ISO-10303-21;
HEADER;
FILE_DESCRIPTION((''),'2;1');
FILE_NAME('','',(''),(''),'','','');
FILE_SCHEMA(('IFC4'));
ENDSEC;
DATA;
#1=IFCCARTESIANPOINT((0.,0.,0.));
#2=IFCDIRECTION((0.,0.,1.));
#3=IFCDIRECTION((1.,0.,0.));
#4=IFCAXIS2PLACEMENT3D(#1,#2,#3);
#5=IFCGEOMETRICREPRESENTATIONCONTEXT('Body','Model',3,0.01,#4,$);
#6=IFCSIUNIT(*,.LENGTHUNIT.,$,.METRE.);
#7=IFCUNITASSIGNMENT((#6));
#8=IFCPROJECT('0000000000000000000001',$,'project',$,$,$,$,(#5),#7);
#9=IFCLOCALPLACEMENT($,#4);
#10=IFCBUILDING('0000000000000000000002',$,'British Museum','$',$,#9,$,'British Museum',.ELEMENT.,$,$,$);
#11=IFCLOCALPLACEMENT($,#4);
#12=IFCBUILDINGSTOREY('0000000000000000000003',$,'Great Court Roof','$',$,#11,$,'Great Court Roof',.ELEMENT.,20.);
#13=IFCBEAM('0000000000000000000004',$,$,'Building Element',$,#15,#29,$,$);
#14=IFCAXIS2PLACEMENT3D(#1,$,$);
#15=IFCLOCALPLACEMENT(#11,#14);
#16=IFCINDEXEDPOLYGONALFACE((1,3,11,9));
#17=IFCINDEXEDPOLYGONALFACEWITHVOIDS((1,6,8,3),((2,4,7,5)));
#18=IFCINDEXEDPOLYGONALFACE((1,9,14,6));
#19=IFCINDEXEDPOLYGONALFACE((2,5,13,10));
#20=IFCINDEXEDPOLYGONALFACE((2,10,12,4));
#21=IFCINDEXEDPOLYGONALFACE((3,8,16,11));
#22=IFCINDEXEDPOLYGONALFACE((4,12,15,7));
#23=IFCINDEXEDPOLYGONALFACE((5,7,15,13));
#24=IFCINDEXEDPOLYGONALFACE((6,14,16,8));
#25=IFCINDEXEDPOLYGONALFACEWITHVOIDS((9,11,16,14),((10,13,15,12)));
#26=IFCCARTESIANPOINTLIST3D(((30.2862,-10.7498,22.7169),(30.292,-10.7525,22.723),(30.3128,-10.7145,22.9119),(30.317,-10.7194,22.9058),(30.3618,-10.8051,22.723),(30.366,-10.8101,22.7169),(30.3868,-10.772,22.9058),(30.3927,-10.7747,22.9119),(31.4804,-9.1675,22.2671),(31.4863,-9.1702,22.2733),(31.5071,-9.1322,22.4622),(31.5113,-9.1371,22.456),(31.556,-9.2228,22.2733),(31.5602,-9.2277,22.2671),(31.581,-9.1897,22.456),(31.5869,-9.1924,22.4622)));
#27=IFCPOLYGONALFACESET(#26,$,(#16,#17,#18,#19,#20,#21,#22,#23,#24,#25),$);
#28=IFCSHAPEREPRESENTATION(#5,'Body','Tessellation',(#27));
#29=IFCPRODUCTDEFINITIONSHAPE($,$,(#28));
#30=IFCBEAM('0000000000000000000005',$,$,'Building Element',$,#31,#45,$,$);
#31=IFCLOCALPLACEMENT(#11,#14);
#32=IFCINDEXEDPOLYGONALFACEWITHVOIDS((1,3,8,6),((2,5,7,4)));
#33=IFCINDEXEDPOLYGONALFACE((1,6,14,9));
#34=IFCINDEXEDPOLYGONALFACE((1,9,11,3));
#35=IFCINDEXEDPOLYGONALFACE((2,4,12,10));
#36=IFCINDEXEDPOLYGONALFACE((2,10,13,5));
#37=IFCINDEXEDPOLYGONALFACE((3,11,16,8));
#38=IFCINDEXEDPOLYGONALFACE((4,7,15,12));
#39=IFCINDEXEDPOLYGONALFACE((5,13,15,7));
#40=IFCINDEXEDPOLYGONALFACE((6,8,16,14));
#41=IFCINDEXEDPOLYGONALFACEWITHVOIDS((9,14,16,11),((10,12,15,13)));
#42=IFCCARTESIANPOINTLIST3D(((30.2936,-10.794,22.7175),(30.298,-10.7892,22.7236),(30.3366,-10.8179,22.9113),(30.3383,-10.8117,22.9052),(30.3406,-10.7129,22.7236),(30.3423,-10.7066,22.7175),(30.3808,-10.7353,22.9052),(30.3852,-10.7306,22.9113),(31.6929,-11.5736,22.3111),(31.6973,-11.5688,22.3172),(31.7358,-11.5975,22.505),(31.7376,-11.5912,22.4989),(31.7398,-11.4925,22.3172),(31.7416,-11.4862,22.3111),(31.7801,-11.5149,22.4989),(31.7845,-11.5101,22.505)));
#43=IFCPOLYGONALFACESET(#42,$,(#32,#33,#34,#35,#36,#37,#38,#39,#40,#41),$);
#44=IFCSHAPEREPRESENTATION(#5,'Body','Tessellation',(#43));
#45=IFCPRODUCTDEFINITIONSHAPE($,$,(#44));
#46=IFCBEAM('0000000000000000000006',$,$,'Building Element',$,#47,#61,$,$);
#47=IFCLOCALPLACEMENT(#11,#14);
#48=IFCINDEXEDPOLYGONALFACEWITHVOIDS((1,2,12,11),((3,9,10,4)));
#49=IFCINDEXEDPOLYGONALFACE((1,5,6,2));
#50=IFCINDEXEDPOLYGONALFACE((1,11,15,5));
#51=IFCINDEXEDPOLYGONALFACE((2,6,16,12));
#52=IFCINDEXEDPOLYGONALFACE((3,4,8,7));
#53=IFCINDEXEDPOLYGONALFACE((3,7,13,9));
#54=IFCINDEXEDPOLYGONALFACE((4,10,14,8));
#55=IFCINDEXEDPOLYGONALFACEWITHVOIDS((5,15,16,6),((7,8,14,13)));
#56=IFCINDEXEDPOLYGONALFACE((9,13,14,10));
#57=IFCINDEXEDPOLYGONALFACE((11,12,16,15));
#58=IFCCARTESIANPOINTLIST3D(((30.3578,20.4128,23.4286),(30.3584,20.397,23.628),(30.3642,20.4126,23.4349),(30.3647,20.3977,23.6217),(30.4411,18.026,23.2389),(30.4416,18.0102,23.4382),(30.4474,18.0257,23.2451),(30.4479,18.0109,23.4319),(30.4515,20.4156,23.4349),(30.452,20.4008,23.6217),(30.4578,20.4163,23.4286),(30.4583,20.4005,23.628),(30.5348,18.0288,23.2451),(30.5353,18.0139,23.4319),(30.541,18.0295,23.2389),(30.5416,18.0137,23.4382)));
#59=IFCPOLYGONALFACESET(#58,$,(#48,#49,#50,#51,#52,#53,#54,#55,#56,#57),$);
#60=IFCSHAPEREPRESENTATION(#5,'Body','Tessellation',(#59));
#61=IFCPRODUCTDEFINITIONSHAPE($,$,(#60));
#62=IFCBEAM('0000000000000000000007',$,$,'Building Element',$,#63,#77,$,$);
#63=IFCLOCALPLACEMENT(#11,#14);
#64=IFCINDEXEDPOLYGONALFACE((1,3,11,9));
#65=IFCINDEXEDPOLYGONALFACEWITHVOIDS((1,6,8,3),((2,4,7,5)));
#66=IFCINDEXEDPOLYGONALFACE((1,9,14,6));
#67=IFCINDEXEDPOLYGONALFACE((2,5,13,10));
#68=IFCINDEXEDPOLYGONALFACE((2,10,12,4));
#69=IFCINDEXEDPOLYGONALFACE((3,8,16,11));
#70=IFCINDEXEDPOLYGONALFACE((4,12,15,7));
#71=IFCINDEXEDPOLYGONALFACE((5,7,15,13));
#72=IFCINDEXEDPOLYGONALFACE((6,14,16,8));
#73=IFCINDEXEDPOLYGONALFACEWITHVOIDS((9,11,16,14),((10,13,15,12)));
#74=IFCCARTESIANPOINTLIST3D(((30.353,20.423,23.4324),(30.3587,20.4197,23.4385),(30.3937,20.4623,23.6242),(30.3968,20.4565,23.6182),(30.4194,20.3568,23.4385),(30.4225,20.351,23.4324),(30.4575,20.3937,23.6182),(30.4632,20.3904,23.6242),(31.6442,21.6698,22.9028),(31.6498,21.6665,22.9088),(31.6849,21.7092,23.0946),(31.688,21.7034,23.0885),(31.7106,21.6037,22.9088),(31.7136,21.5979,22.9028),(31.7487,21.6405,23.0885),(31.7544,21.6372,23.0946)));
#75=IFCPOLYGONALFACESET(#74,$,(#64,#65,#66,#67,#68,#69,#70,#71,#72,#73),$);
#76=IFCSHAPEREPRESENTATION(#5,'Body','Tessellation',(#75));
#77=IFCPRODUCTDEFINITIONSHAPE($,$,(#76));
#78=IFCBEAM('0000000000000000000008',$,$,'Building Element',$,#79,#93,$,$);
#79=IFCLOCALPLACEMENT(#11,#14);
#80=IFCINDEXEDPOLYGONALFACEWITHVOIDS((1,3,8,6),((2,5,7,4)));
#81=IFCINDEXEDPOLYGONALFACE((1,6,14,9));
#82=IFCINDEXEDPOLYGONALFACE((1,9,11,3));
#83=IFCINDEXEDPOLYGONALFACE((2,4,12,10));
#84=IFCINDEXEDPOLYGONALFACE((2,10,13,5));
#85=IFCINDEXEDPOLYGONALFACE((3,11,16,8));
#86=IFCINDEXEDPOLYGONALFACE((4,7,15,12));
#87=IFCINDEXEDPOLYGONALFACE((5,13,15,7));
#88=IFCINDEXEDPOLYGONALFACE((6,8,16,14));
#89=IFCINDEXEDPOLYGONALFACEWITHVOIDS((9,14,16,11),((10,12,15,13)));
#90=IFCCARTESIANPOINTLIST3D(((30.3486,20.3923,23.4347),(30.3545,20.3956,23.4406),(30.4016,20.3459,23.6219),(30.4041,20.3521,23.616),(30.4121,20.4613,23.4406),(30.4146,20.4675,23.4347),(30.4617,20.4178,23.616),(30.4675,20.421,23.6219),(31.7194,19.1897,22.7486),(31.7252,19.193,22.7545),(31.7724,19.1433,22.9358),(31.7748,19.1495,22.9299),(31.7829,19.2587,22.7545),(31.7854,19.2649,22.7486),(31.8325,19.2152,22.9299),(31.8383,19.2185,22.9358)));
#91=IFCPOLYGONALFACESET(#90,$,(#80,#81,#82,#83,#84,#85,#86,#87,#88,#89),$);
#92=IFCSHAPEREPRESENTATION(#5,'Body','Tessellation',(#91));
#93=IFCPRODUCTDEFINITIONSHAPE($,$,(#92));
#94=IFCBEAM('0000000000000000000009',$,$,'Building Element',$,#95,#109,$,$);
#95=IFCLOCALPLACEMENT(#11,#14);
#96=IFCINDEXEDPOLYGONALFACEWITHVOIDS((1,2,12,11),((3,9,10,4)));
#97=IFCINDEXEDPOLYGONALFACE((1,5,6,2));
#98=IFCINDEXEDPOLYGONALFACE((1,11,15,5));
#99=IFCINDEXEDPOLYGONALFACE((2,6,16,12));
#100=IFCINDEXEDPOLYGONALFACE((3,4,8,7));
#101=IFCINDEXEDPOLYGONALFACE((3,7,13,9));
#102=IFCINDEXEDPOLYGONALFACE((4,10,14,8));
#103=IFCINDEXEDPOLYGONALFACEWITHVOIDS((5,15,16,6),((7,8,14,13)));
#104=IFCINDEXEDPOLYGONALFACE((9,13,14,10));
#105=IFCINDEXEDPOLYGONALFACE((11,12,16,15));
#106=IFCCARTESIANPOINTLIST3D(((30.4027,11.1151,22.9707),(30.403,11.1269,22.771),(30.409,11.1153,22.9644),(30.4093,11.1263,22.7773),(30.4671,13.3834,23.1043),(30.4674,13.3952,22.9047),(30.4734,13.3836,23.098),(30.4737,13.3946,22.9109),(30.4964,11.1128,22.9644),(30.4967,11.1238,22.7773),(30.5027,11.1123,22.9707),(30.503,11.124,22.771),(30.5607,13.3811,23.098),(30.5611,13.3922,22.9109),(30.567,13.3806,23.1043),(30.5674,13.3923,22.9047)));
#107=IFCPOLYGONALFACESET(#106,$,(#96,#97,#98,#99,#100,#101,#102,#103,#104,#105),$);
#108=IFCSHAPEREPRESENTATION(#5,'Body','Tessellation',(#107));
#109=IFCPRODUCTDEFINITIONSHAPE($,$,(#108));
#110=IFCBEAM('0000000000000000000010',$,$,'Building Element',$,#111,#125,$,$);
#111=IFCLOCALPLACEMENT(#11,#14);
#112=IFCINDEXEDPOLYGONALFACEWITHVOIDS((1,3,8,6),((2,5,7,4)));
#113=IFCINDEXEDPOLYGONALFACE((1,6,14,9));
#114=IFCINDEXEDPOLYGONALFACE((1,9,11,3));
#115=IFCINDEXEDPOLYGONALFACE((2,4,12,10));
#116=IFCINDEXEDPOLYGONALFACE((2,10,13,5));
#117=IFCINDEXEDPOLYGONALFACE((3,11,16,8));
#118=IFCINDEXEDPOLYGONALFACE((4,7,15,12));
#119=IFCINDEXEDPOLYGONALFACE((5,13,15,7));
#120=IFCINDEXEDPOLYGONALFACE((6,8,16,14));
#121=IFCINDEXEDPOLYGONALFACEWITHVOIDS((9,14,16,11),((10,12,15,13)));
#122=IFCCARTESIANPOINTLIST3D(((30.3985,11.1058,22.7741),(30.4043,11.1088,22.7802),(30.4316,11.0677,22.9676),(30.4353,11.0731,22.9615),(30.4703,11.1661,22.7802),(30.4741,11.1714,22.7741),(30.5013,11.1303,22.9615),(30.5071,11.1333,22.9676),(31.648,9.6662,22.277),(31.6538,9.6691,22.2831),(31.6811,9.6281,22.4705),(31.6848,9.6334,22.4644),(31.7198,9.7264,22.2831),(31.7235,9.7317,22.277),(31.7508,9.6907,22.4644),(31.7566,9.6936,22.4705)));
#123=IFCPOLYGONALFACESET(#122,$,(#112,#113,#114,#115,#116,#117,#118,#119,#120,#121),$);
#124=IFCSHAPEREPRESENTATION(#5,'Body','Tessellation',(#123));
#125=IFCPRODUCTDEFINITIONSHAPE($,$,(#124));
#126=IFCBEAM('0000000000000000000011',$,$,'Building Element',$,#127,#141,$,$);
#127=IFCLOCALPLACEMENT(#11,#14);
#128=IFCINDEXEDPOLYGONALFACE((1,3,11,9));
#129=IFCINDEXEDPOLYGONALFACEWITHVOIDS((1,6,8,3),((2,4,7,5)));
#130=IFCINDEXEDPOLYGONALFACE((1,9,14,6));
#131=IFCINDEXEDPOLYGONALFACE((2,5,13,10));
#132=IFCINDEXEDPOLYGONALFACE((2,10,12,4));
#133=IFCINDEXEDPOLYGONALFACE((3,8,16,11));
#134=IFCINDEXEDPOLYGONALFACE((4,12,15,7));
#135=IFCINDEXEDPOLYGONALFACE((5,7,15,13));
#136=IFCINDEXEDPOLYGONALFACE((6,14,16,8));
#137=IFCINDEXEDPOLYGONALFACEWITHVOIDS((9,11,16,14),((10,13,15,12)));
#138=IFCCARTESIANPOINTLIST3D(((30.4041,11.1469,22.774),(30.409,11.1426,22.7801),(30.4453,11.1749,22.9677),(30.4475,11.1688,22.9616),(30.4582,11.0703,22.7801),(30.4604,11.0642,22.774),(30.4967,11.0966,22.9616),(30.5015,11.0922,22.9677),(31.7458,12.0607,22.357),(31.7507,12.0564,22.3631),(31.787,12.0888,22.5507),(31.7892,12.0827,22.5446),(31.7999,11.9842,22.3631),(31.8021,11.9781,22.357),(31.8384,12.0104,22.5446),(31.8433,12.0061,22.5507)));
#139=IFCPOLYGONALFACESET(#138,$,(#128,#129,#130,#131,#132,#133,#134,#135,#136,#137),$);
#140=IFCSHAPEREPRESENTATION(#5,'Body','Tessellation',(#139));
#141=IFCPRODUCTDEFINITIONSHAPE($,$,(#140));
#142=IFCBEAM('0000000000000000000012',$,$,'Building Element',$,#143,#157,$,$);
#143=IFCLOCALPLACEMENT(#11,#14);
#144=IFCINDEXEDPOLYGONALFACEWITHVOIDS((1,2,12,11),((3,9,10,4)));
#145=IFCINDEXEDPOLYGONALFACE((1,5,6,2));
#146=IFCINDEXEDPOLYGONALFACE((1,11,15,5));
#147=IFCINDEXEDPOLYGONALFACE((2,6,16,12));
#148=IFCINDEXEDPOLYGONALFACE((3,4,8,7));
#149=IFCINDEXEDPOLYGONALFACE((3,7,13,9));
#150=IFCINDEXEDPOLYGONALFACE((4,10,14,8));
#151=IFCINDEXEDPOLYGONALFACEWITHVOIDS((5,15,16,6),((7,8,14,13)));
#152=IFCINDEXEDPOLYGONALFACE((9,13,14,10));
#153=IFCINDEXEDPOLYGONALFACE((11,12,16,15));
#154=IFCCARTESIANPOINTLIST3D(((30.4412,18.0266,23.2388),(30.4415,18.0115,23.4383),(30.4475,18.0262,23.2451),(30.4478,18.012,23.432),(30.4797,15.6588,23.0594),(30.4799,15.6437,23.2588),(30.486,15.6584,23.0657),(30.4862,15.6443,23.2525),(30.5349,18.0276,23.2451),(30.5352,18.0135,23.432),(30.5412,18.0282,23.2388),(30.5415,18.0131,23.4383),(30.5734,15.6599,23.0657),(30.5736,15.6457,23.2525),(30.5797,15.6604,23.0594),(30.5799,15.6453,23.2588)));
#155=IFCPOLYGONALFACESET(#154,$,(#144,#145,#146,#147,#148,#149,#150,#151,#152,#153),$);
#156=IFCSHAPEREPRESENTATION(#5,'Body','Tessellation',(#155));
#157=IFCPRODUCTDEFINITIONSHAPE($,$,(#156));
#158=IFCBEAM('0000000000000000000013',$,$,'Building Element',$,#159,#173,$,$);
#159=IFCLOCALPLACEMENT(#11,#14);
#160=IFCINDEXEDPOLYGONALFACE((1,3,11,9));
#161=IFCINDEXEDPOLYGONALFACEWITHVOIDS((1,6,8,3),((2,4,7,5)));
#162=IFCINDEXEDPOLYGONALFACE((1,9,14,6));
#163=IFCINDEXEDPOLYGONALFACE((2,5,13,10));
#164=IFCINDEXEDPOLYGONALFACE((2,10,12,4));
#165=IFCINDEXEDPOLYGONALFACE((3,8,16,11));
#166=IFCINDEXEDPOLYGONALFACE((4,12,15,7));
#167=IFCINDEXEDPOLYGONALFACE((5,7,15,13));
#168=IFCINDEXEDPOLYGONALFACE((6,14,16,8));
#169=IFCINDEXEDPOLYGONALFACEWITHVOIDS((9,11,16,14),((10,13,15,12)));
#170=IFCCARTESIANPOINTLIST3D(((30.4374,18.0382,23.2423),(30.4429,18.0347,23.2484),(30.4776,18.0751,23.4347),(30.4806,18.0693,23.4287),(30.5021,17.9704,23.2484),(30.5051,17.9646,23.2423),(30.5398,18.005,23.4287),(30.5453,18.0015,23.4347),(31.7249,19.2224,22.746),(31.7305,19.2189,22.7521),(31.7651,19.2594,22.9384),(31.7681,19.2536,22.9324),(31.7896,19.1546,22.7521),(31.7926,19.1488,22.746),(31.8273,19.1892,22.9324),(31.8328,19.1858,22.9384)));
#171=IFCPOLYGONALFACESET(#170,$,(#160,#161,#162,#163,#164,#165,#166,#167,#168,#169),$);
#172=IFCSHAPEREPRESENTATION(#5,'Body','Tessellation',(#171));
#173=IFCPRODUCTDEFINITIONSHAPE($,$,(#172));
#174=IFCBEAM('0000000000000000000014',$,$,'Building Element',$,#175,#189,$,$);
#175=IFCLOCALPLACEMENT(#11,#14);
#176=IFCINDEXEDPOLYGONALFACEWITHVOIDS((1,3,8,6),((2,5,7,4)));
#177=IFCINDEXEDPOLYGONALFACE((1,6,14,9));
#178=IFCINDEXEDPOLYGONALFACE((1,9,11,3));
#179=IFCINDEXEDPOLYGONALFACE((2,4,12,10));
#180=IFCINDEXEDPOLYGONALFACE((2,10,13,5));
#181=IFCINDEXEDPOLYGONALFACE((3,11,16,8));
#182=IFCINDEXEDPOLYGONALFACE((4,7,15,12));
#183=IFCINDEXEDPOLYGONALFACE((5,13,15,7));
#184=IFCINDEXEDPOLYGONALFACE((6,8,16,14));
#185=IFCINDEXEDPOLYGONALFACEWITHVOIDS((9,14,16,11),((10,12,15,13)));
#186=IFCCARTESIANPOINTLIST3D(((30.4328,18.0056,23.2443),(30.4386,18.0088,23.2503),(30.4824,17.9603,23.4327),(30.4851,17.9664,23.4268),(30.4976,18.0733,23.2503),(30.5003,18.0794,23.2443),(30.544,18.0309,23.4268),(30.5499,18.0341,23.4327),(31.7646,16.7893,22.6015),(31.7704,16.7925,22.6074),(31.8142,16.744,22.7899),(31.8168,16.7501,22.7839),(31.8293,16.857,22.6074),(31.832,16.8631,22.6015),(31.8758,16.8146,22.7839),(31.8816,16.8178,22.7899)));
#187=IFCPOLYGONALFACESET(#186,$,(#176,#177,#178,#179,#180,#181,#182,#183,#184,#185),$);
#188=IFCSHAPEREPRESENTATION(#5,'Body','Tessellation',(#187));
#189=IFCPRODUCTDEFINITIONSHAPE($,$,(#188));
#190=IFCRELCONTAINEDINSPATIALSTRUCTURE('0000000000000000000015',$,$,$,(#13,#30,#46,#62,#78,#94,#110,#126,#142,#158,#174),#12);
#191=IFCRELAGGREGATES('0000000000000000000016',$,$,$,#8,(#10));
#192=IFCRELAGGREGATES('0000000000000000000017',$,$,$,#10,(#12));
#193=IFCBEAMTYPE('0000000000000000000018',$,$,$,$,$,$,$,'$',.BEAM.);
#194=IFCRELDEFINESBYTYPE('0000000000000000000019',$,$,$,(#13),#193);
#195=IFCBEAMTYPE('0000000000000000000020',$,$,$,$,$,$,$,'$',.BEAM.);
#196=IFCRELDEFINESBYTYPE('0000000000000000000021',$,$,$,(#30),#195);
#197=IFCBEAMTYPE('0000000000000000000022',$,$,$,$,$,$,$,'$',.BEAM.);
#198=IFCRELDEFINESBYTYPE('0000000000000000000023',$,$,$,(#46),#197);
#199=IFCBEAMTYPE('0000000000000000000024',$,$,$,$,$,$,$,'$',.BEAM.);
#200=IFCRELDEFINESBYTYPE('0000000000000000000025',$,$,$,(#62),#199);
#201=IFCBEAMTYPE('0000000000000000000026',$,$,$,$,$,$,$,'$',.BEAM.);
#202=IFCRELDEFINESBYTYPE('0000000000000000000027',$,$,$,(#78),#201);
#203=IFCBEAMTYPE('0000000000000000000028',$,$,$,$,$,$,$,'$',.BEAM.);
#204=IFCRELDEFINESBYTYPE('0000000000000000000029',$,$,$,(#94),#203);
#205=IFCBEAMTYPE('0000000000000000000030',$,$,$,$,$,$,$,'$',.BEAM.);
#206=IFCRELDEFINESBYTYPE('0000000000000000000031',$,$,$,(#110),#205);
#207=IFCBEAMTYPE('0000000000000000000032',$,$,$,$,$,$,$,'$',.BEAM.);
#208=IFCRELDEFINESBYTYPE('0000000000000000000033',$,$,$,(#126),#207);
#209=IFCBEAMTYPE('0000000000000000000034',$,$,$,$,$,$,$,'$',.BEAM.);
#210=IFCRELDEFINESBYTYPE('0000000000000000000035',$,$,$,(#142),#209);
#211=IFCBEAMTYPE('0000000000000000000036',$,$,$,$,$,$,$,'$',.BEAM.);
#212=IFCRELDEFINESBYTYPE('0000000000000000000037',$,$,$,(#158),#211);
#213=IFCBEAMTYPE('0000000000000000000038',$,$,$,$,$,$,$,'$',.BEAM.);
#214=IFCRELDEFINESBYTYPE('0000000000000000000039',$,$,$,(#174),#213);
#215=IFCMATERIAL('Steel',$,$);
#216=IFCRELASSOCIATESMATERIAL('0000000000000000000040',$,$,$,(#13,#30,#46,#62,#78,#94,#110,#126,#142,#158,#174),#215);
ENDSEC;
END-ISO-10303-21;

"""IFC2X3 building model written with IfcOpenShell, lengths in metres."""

from ifc_helpers import new_model, si_unit, frame, origin_with_axes, origin_2d, place, context, project, spatial, hollow_rectangle, extrude, material, type_object, element, save


model = new_model("IFC2X3")

# Units and contexts
model_context = context("Model", 3, precision=0.01, world=origin_with_axes(), identifier="Body")
ifc_project = project(units=[si_unit("LENGTHUNIT", "METRE")], contexts=[model_context])

# Building, storey
building_placement = place(None, origin_with_axes())
building = spatial("IfcBuilding", under=ifc_project, at=building_placement, Name="British Museum", Description="$", LongName="British Museum", CompositionType="ELEMENT")
storey_placement = place(None, origin_with_axes())
storey = spatial("IfcBuildingStorey", under=building, at=storey_placement, Name="Great Court Roof", Description="$", LongName="Great Court Roof", CompositionType="ELEMENT", Elevation=20.0)

# Beams
ifc_material = material(Name="Steel")
beam_type_1 = type_object("IfcBeamType", ElementType="$", PredefinedType="BEAM")
beam_1_placement = place(None, origin_with_axes())
element("IfcBeam", 1, at=beam_1_placement, inside=storey, type_object=beam_type_1, material=ifc_material, Description="Building Element", context=model_context, shape_type="SweptSolid", body=[
    extrude(hollow_rectangle(XDim=0.1, YDim=0.2, WallThickness=0.0063, InnerFilletRadius=-0.0063, OuterFilletRadius=0.0, at=origin_2d()), frame((30.3394, -10.7623, 22.8144), z_axis=(0.58749, 0.778397, -0.221254), x_axis=(-0.798179, 0.602421, 0.0)), (0.0, 0.0, 1.0), 2.0328),
])
beam_type_2 = type_object("IfcBeamType", ElementType="$", PredefinedType="BEAM")
beam_2_placement = place(None, origin_with_axes())
element("IfcBeam", 2, at=beam_2_placement, inside=storey, type_object=beam_type_2, material=ifc_material, Description="Building Element", context=model_context, shape_type="SweptSolid", body=[
    extrude(hollow_rectangle(XDim=0.1, YDim=0.2, WallThickness=0.0063, InnerFilletRadius=-0.0063, OuterFilletRadius=0.0, at=origin_2d()), frame((30.3394, -10.7623, 22.8144), z_axis=(0.846754, -0.471749, -0.245886), x_axis=(0.486691, 0.873574, 0.0)), (0.0, 0.0, 1.0), 1.6525),
])
beam_type_3 = type_object("IfcBeamType", ElementType="$", PredefinedType="BEAM")
beam_3_placement = place(None, origin_with_axes())
element("IfcBeam", 3, at=beam_3_placement, inside=storey, type_object=beam_type_3, material=ifc_material, Description="Building Element", context=model_context, shape_type="SweptSolid", body=[
    extrude(hollow_rectangle(XDim=0.1, YDim=0.2, WallThickness=0.0063, InnerFilletRadius=-0.0063, OuterFilletRadius=0.0, at=origin_2d()), frame((30.4081, 20.4067, 23.5283), z_axis=(0.03475, -0.996252, -0.079214), x_axis=(0.999392, 0.034859, 0.0)), (0.0, 0.0, 1.0), 2.3958),
])
beam_type_4 = type_object("IfcBeamType", ElementType="$", PredefinedType="BEAM")
beam_4_placement = place(None, origin_with_axes())
element("IfcBeam", 4, at=beam_4_placement, inside=storey, type_object=beam_type_4, material=ifc_material, Description="Building Element", context=model_context, shape_type="SweptSolid", body=[
    extrude(hollow_rectangle(XDim=0.1, YDim=0.2, WallThickness=0.0063, InnerFilletRadius=-0.0063, OuterFilletRadius=0.0, at=origin_2d()), frame((30.4081, 20.4067, 23.5283), z_axis=(0.689934, 0.666252, -0.28302), x_axis=(-0.694653, 0.719345, 0.0)), (0.0, 0.0, 1.0), 1.8715),
])
beam_type_5 = type_object("IfcBeamType", ElementType="$", PredefinedType="BEAM")
beam_5_placement = place(None, origin_with_axes())
element("IfcBeam", 5, at=beam_5_placement, inside=storey, type_object=beam_type_5, material=ifc_material, Description="Building Element", context=model_context, shape_type="SweptSolid", body=[
    extrude(hollow_rectangle(XDim=0.1, YDim=0.2, WallThickness=0.0063, InnerFilletRadius=-0.0063, OuterFilletRadius=0.0, at=origin_2d()), frame((30.4081, 20.4067, 23.5283), z_axis=(0.703565, -0.61724, -0.352153), x_axis=(0.659485, 0.751718, 0.0)), (0.0, 0.0, 1.0), 1.9483),
])
beam_type_6 = type_object("IfcBeamType", ElementType="$", PredefinedType="BEAM")
beam_6_placement = place(None, origin_with_axes())
element("IfcBeam", 6, at=beam_6_placement, inside=storey, type_object=beam_type_6, material=ifc_material, Description="Building Element", context=model_context, shape_type="SweptSolid", body=[
    extrude(hollow_rectangle(XDim=0.1, YDim=0.2, WallThickness=0.0063, InnerFilletRadius=-0.0063, OuterFilletRadius=0.0, at=origin_2d()), frame((30.4528, 11.1196, 22.8708), z_axis=(0.028319, 0.997869, 0.058792), x_axis=(-0.999598, 0.028368, 0.0)), (0.0, 0.0, 1.0), 2.2732),
])
beam_type_7 = type_object("IfcBeamType", ElementType="$", PredefinedType="BEAM")
beam_7_placement = place(None, origin_with_axes())
element("IfcBeam", 7, at=beam_7_placement, inside=storey, type_object=beam_type_7, material=ifc_material, Description="Building Element", context=model_context, shape_type="SweptSolid", body=[
    extrude(hollow_rectangle(XDim=0.1, YDim=0.2, WallThickness=0.0063, InnerFilletRadius=-0.0063, OuterFilletRadius=0.0, at=origin_2d()), frame((30.4528, 11.1196, 22.8708), z_axis=(0.634239, -0.730799, -0.252336), x_axis=(0.755239, 0.65545, 0.0)), (0.0, 0.0, 1.0), 1.97),
])
beam_type_8 = type_object("IfcBeamType", ElementType="$", PredefinedType="BEAM")
beam_8_placement = place(None, origin_with_axes())
element("IfcBeam", 8, at=beam_8_placement, inside=storey, type_object=beam_type_8, material=ifc_material, Description="Building Element", context=model_context, shape_type="SweptSolid", body=[
    extrude(hollow_rectangle(XDim=0.1, YDim=0.2, WallThickness=0.0063, InnerFilletRadius=-0.0063, OuterFilletRadius=0.0, at=origin_2d()), frame((30.4528, 11.1196, 22.8708), z_axis=(0.800507, 0.545238, -0.248803), x_axis=(-0.562941, 0.826497, 0.0)), (0.0, 0.0, 1.0), 1.6761),
])
beam_type_9 = type_object("IfcBeamType", ElementType="$", PredefinedType="BEAM")
beam_9_placement = place(None, origin_with_axes())
element("IfcBeam", 9, at=beam_9_placement, inside=storey, type_object=beam_type_9, material=ifc_material, Description="Building Element", context=model_context, shape_type="SweptSolid", body=[
    extrude(hollow_rectangle(XDim=0.1, YDim=0.2, WallThickness=0.0063, InnerFilletRadius=-0.0063, OuterFilletRadius=0.0, at=origin_2d()), frame((30.4913, 18.0198, 23.3385), z_axis=(0.016198, -0.99701, -0.075552), x_axis=(0.999868, 0.016245, 0.0)), (0.0, 0.0, 1.0), 2.3749),
])
beam_type_10 = type_object("IfcBeamType", ElementType="$", PredefinedType="BEAM")
beam_10_placement = place(None, origin_with_axes())
element("IfcBeam", 10, at=beam_10_placement, inside=storey, type_object=beam_type_10, material=ifc_material, Description="Building Element", context=model_context, shape_type="SweptSolid", body=[
    extrude(hollow_rectangle(XDim=0.1, YDim=0.2, WallThickness=0.0063, InnerFilletRadius=-0.0063, OuterFilletRadius=0.0, at=origin_2d()), frame((30.4913, 18.0198, 23.3385), z_axis=(0.708057, 0.651271, -0.272949), x_axis=(-0.676977, 0.736004, 0.0)), (0.0, 0.0, 1.0), 1.8184),
])
beam_type_11 = type_object("IfcBeamType", ElementType="$", PredefinedType="BEAM")
beam_11_placement = place(None, origin_with_axes())
element("IfcBeam", 11, at=beam_11_placement, inside=storey, type_object=beam_type_11, material=ifc_material, Description="Building Element", context=model_context, shape_type="SweptSolid", body=[
    extrude(hollow_rectangle(XDim=0.1, YDim=0.2, WallThickness=0.0063, InnerFilletRadius=-0.0063, OuterFilletRadius=0.0, at=origin_2d()), frame((30.4913, 18.0198, 23.3385), z_axis=(0.695528, -0.635231, -0.335741), x_axis=(0.674375, 0.738389, 0.0)), (0.0, 0.0, 1.0), 1.9147),
])

save(model, "model.ifc")
